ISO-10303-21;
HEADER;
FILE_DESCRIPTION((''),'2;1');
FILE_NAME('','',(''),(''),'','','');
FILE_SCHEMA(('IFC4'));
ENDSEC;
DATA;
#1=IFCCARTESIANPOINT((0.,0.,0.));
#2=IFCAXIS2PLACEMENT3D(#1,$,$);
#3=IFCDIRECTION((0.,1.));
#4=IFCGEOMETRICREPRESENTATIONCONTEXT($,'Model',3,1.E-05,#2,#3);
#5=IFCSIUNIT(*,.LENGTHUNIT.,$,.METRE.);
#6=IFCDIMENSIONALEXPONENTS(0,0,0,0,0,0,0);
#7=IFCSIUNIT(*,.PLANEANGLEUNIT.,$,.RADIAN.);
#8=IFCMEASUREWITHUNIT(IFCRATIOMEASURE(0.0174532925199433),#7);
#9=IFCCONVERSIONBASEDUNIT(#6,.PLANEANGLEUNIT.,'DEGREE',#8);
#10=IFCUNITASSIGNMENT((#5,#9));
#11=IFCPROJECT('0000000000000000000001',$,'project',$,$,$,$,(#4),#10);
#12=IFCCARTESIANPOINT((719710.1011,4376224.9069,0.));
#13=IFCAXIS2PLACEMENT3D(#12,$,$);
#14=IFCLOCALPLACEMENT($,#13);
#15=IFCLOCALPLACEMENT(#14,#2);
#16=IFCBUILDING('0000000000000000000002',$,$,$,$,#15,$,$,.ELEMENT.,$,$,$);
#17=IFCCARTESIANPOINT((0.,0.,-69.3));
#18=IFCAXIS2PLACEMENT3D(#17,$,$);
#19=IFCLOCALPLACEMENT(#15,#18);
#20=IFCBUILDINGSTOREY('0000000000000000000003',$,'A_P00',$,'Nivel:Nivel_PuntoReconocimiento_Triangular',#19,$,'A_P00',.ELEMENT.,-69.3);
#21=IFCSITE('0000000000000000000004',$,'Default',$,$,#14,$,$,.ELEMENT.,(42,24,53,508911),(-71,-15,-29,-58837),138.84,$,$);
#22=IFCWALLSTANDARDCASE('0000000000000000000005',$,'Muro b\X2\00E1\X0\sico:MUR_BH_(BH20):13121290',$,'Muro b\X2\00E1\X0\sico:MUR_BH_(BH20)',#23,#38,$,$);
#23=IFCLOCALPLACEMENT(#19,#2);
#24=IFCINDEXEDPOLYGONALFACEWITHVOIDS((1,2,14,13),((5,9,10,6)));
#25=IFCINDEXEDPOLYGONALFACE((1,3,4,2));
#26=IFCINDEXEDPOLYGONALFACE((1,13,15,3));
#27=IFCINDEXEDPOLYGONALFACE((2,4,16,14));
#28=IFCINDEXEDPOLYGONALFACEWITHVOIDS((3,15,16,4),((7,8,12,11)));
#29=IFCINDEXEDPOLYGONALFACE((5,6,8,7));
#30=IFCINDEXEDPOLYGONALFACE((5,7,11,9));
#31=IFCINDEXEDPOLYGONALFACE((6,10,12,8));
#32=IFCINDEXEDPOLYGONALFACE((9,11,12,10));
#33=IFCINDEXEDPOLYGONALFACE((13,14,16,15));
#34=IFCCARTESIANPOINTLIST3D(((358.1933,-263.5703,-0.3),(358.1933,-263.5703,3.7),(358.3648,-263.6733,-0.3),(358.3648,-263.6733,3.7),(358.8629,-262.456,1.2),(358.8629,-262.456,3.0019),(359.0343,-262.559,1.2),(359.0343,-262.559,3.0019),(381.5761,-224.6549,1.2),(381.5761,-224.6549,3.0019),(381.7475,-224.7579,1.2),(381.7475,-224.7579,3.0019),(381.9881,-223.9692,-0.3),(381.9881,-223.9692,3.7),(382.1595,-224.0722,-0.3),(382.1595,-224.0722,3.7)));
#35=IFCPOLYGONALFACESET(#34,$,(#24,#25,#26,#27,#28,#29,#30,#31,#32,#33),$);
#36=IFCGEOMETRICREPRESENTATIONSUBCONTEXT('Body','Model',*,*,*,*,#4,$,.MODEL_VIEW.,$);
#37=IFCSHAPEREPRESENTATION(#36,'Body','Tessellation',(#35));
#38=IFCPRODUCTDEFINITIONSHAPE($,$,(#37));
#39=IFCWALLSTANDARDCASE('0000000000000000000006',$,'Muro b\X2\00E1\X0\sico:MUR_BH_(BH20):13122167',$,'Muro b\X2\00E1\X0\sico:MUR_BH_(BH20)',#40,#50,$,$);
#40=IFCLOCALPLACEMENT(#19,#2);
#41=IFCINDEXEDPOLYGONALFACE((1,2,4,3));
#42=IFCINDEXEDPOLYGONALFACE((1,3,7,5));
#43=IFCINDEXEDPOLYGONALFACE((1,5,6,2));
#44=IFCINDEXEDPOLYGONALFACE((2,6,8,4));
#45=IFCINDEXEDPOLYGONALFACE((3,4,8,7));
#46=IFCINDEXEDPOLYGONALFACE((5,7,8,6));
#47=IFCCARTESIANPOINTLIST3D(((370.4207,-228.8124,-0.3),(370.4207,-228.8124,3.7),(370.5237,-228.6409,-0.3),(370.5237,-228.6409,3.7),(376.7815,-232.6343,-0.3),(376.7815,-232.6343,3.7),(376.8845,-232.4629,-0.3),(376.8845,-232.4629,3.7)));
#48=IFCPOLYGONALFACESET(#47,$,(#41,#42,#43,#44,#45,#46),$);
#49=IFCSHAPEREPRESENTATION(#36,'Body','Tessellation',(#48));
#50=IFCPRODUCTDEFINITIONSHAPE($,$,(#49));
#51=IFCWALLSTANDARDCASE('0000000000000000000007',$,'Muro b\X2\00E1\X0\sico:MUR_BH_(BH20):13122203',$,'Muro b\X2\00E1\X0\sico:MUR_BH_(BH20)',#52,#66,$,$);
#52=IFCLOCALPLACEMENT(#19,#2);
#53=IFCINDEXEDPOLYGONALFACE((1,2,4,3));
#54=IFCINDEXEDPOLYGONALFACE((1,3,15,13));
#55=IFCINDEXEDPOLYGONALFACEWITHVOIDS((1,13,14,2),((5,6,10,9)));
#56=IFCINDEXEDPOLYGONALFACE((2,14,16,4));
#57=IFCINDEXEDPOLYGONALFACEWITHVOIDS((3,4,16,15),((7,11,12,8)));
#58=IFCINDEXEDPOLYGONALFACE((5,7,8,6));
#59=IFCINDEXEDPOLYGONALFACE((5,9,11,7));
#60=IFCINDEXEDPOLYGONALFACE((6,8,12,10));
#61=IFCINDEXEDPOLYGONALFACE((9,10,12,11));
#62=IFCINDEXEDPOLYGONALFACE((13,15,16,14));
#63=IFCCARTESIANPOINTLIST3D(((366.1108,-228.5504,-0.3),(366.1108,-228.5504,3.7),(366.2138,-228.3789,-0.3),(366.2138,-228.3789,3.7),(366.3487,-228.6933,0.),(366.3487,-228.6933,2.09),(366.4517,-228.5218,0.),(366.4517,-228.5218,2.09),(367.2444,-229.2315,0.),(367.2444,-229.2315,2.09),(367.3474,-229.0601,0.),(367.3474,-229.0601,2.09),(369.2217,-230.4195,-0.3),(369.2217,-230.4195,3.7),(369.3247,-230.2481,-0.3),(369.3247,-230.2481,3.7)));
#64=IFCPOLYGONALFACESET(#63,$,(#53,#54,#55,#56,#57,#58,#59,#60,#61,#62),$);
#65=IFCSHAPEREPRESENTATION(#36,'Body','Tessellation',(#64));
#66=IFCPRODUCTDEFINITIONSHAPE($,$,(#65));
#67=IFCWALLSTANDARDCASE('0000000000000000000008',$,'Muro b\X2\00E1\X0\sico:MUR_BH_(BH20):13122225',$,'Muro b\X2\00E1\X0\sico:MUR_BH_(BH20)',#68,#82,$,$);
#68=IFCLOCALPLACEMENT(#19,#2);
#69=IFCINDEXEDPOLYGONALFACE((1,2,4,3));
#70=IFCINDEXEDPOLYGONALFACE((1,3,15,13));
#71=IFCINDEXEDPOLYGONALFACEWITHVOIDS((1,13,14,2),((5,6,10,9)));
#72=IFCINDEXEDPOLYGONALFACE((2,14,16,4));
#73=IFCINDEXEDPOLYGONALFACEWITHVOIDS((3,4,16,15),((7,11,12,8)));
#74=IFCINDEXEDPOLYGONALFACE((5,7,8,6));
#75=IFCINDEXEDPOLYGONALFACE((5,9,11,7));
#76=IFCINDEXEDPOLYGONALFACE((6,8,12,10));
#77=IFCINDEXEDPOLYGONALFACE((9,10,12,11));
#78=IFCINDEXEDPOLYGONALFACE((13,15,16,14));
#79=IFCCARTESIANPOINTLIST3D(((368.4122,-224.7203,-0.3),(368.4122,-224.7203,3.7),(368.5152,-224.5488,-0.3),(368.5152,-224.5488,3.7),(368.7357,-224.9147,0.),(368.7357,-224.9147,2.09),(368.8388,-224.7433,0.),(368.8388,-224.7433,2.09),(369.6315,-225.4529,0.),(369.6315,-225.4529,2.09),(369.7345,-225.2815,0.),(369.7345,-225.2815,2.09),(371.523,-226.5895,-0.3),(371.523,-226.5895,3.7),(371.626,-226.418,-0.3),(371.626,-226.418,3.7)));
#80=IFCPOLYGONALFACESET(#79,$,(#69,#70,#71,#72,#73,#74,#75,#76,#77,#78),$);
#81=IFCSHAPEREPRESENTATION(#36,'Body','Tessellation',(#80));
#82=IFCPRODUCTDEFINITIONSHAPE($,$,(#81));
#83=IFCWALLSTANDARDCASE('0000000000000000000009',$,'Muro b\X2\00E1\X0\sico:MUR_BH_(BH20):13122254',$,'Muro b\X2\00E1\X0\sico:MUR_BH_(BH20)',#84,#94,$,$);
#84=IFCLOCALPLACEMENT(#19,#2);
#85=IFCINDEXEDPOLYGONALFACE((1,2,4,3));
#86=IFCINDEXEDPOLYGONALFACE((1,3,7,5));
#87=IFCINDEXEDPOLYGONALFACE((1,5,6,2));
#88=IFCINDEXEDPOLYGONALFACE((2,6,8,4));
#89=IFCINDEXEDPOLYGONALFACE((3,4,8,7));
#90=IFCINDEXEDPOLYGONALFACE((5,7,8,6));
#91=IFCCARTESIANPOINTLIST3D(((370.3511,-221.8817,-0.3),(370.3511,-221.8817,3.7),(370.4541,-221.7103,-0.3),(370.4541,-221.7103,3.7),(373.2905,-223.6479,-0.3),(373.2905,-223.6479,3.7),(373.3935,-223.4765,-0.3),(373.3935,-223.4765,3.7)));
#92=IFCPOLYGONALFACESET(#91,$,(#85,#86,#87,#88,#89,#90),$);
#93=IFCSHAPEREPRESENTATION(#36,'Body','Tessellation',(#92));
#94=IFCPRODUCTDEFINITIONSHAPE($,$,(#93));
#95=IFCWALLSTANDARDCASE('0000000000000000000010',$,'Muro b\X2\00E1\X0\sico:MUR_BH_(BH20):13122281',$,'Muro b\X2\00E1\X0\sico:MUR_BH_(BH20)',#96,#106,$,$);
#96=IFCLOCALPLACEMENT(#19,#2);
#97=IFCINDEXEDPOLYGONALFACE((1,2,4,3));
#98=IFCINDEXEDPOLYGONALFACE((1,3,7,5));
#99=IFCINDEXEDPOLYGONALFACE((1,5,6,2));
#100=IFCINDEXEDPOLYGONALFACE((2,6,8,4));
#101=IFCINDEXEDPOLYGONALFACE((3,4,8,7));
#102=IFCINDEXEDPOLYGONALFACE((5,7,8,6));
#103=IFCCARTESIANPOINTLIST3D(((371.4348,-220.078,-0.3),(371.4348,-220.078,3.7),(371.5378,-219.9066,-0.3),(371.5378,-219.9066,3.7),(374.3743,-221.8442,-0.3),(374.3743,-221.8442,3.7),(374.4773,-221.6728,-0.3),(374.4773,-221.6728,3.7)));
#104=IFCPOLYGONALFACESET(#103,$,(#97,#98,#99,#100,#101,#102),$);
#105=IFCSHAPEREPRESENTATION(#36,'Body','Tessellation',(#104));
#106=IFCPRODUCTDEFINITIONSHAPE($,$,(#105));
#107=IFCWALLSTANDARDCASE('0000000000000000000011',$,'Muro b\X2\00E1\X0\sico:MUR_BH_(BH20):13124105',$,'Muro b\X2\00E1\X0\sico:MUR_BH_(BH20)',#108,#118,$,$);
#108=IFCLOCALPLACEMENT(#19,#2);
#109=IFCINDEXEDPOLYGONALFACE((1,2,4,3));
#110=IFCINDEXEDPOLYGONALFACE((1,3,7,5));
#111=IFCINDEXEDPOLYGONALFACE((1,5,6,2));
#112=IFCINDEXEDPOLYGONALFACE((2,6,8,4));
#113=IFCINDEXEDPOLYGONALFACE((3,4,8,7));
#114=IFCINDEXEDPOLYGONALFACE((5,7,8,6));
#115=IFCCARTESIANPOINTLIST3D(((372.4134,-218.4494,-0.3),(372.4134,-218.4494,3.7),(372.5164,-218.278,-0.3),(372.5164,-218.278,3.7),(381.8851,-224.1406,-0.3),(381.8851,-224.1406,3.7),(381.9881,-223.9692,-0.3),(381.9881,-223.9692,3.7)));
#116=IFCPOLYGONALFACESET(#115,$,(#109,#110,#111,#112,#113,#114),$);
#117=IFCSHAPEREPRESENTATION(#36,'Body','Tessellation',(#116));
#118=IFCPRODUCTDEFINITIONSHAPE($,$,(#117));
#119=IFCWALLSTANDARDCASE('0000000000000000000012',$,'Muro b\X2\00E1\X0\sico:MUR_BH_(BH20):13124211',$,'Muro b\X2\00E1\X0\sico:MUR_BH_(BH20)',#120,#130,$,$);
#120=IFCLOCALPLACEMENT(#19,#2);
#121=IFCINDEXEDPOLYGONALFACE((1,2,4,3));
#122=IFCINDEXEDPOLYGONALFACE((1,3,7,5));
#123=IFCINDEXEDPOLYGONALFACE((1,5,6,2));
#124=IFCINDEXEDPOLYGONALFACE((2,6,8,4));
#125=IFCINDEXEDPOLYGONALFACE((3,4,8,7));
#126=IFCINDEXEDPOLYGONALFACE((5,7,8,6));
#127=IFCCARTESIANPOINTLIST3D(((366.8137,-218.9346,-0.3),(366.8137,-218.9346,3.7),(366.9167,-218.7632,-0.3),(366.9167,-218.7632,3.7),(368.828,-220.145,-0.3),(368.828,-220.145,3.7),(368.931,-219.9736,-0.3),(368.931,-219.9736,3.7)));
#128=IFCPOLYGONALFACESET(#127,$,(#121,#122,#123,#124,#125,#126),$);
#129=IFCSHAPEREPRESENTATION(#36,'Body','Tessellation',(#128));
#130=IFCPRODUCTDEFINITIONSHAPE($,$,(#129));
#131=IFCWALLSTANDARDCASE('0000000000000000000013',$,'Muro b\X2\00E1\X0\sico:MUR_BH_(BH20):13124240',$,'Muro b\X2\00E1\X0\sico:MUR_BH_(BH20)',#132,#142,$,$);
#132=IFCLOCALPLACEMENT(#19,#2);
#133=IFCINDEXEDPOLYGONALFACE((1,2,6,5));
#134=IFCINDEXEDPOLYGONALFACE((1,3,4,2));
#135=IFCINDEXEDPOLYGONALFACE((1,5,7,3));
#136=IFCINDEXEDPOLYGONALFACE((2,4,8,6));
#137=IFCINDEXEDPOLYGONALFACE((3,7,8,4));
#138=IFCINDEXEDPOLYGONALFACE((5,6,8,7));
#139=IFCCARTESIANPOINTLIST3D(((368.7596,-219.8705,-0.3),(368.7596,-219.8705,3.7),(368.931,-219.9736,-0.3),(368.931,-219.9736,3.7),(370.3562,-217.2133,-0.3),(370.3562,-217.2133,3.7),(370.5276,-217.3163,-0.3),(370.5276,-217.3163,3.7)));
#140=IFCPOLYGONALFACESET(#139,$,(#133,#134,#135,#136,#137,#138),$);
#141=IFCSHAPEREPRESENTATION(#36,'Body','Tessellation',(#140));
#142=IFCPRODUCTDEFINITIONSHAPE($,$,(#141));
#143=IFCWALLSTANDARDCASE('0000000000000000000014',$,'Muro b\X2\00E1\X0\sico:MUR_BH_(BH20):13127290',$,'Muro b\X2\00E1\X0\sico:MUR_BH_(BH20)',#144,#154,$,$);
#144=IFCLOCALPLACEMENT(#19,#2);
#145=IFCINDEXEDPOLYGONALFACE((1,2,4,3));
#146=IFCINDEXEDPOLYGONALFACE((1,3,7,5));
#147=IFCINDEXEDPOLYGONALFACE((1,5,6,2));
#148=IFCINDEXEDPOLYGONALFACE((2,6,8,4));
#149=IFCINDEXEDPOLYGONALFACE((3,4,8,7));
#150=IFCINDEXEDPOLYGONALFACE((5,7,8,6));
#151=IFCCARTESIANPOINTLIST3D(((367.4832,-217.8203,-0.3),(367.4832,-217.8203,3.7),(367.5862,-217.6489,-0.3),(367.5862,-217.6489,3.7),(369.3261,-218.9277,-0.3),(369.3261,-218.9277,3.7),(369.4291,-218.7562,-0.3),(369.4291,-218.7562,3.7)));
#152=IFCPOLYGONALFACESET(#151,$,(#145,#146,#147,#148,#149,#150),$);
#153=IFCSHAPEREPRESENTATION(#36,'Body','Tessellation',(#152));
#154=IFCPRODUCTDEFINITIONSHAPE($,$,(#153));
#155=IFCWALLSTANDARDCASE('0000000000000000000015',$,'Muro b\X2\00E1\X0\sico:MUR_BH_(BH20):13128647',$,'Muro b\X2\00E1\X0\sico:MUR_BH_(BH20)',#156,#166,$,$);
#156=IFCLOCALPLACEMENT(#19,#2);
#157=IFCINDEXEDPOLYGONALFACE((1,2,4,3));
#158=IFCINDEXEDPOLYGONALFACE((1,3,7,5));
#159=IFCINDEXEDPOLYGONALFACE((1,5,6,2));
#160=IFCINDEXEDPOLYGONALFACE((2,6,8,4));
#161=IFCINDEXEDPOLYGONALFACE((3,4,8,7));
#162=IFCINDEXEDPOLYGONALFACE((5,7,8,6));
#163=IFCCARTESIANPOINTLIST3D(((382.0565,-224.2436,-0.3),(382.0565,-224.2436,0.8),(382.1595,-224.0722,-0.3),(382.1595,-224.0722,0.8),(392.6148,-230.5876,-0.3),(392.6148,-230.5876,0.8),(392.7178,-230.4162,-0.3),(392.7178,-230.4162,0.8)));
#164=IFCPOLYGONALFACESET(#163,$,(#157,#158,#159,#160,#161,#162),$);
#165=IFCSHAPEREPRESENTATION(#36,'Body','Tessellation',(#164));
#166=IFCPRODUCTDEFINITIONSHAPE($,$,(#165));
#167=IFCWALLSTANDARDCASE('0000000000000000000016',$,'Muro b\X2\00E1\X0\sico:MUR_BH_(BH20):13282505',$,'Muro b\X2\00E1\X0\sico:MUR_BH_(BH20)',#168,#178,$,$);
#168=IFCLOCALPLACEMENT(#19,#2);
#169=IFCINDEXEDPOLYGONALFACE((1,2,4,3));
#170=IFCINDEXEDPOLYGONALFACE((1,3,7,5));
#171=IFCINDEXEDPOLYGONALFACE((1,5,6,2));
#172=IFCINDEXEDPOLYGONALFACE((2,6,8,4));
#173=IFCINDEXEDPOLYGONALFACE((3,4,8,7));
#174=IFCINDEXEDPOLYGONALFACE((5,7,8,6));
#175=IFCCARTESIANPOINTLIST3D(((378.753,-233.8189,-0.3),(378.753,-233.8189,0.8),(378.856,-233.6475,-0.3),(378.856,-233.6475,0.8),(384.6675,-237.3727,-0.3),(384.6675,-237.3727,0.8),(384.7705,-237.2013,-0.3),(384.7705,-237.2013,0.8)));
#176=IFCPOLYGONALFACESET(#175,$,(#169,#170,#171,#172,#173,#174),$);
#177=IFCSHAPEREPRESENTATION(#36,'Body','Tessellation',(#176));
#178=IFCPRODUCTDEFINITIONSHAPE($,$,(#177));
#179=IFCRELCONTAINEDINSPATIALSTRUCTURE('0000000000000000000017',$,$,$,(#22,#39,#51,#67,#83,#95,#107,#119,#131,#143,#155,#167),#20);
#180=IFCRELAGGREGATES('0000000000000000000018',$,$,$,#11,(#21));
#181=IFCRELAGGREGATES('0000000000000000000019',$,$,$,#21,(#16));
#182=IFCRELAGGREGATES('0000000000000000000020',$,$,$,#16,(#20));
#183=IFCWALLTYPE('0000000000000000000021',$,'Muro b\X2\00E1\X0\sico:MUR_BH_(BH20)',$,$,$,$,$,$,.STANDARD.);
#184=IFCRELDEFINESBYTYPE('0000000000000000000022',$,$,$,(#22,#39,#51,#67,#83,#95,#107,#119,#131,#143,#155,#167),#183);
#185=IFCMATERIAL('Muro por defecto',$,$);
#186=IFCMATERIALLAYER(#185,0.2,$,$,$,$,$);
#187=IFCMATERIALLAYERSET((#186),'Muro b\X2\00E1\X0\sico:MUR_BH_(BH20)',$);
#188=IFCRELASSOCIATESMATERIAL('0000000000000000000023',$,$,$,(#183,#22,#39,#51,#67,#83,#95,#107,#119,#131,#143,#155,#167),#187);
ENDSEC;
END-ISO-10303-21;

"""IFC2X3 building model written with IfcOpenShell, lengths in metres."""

from ifc_helpers import new_model, entity, si_unit, converted_unit, direction, frame, frame_2d, origin, place, context, subcontext, project, spatial, rectangle, extrude, material, layer, layer_set, layer_usage, type_object, element, save


model = new_model("IFC2X3")

# Units and contexts
model_context = context("Model", 3, precision=1e-05, world=origin(), true_north=direction((0.0, 1.0)))
body_context = subcontext(model_context, "Body", "Model", "MODEL_VIEW")
ifc_project = project(units=[si_unit("LENGTHUNIT", "METRE"), converted_unit("PLANEANGLEUNIT", "DEGREE", entity("IfcRatioMeasure", 0.0174532925199433), si_unit("PLANEANGLEUNIT", "RADIAN"), dimensions=[0, 0, 0, 0, 0, 0, 0])], contexts=[model_context])

# Site, building, storey
site_placement = place(None, frame((719710.1011, 4376224.9069, 0.0)))
site = spatial("IfcSite", under=ifc_project, at=site_placement, Name="Default", CompositionType="ELEMENT", RefLatitude=(42, 24, 53, 508911), RefLongitude=(-71, -15, -29, -58837), RefElevation=138.84)
building_placement = place(site_placement, origin())
building = spatial("IfcBuilding", under=site, at=building_placement, CompositionType="ELEMENT")
storey_placement = place(building_placement, frame((0.0, 0.0, -69.3)))
storey = spatial("IfcBuildingStorey", under=building, at=storey_placement, Name="A_P00", ObjectType="Nivel:Nivel_PuntoReconocimiento_Triangular", LongName="A_P00", CompositionType="ELEMENT", Elevation=-69.3)

# Wall, opening
ifc_material_1 = material(Name="Muro por defecto")
ifc_layer = layer(ifc_material_1, 0.2)
ifc_layer_set = layer_set([ifc_layer], Name="Muro básico:MUR_BH_(BH20)")
wall_type = type_object("IfcWallType", Name="Muro básico:MUR_BH_(BH20)", PredefinedType="STANDARD", material=ifc_layer_set)
ifc_layer_usage_1 = layer_usage(ifc_layer_set, "AXIS2", "NEGATIVE", 0.1)
wall_1_placement = place(storey_placement, frame((382.0738, -224.0207, -0.3), z_axis=(0.0, 0.0, 1.0), x_axis=(-0.515038, -0.857167, 0.0)))
wall_1 = element("IfcWallStandardCase", 1, at=wall_1_placement, inside=storey, type_object=wall_type, material=ifc_layer_usage_1, Name="Muro básico:MUR_BH_(BH20):13121290", ObjectType="Muro básico:MUR_BH_(BH20)", context=body_context, shape_type="SweptSolid", body=[
    extrude(rectangle(XDim=46.2, YDim=0.2, at=frame_2d((23.1, 0.0), x_axis=(-1.0, 0.0))), origin(), (0.0, 0.0, 1.0), 4.0),
])
opening_1_placement = place(wall_1_placement, origin())
element("IfcOpeningElement", 2, at=opening_1_placement, cuts=wall_1, ObjectType="Opening", context=body_context, shape_type="SweptSolid", body=[
    extrude(rectangle(XDim=1.8019, YDim=44.1, at=frame_2d((0.0, 0.0), x_axis=(0.0, 1.0))), frame((22.85, -0.2524, 2.4009), z_axis=(0.0, 1.0, 0.0), x_axis=(-1.0, 0.0, 0.0)), (0.0, 0.0, 1.0), 0.5048),
])

# Wall
ifc_layer_usage_2 = layer_usage(ifc_layer_set, "AXIS2", "NEGATIVE", 0.1)
wall_2_placement = place(storey_placement, frame((370.4722, -228.7266, -0.3), z_axis=(0.0, 0.0, 1.0), x_axis=(0.857167, -0.515038, 0.0)))
element("IfcWallStandardCase", 3, at=wall_2_placement, inside=storey, type_object=wall_type, material=ifc_layer_usage_2, Name="Muro básico:MUR_BH_(BH20):13122167", ObjectType="Muro básico:MUR_BH_(BH20)", context=body_context, shape_type="SweptSolid", body=[
    extrude(rectangle(XDim=7.4208, YDim=0.2, at=frame_2d((3.7104, 0.0), x_axis=(-1.0, 0.0))), origin(), (0.0, 0.0, 1.0), 4.0),
])

# Walls, openings
ifc_layer_usage_3 = layer_usage(ifc_layer_set, "AXIS2", "NEGATIVE", 0.1)
wall_3_placement = place(storey_placement, frame((366.1623, -228.4646, -0.3), z_axis=(0.0, 0.0, 1.0), x_axis=(0.857167, -0.515038, 0.0)))
wall_3 = element("IfcWallStandardCase", 4, at=wall_3_placement, inside=storey, type_object=wall_type, material=ifc_layer_usage_3, Name="Muro básico:MUR_BH_(BH20):13122203", ObjectType="Muro básico:MUR_BH_(BH20)", context=body_context, shape_type="SweptSolid", body=[
    extrude(rectangle(XDim=3.6292, YDim=0.2, at=frame_2d((1.8146, 0.0), x_axis=(-1.0, 0.0))), origin(), (0.0, 0.0, 1.0), 4.0),
])
opening_2_placement = place(wall_3_placement, frame((-431.5304, 7.2449, 0.3), z_axis=(0.0, 0.0, 1.0), x_axis=(0.857167, 0.515038, 0.0)))
element("IfcOpeningElement", 5, at=opening_2_placement, cuts=wall_3, ObjectType="Opening", context=body_context, shape_type="SweptSolid", body=[
    extrude(rectangle(XDim=2.09, YDim=1.045, at=frame_2d((0.0, 0.0), x_axis=(0.0, 1.0))), frame((366.7966, -228.9624, 1.045), z_axis=(0.515038, 0.857167, 0.0), x_axis=(0.857167, -0.515038, 0.0)), (0.0, 0.0, 1.0), 0.2),
])
ifc_layer_usage_4 = layer_usage(ifc_layer_set, "AXIS2", "NEGATIVE", 0.1)
wall_4_placement = place(storey_placement, frame((368.4637, -224.6346, -0.3), z_axis=(0.0, 0.0, 1.0), x_axis=(0.857167, -0.515038, 0.0)))
wall_4 = element("IfcWallStandardCase", 6, at=wall_4_placement, inside=storey, type_object=wall_type, material=ifc_layer_usage_4, Name="Muro básico:MUR_BH_(BH20):13122225", ObjectType="Muro básico:MUR_BH_(BH20)", context=body_context, shape_type="SweptSolid", body=[
    extrude(rectangle(XDim=3.6292, YDim=0.2, at=frame_2d((1.8146, 0.0), x_axis=(-1.0, 0.0))), origin(), (0.0, 0.0, 1.0), 4.0),
])
opening_3_placement = place(wall_4_placement, frame((-431.5304, 2.7766, 0.3), z_axis=(0.0, 0.0, 1.0), x_axis=(0.857167, 0.515038, 0.0)))
element("IfcOpeningElement", 7, at=opening_3_placement, cuts=wall_4, ObjectType="Opening", context=body_context, shape_type="SweptSolid", body=[
    extrude(rectangle(XDim=2.09, YDim=1.045, at=frame_2d((0.0, 0.0), x_axis=(0.0, 1.0))), frame((369.1836, -225.1838, 1.045), z_axis=(0.515038, 0.857167, 0.0), x_axis=(0.857167, -0.515038, 0.0)), (0.0, 0.0, 1.0), 0.2),
])

# Walls
ifc_layer_usage_5 = layer_usage(ifc_layer_set, "AXIS2", "NEGATIVE", 0.1)
wall_5_placement = place(storey_placement, frame((370.4026, -221.796, -0.3), z_axis=(0.0, 0.0, 1.0), x_axis=(0.857167, -0.515038, 0.0)))
element("IfcWallStandardCase", 8, at=wall_5_placement, inside=storey, type_object=wall_type, material=ifc_layer_usage_5, Name="Muro básico:MUR_BH_(BH20):13122254", ObjectType="Muro básico:MUR_BH_(BH20)", context=body_context, shape_type="SweptSolid", body=[
    extrude(rectangle(XDim=3.4292, YDim=0.2, at=frame_2d((1.7146, 0.0), x_axis=(-1.0, 0.0))), origin(), (0.0, 0.0, 1.0), 4.0),
])
ifc_layer_usage_6 = layer_usage(ifc_layer_set, "AXIS2", "NEGATIVE", 0.1)
wall_6_placement = place(storey_placement, frame((371.4863, -219.9923, -0.3), z_axis=(0.0, 0.0, 1.0), x_axis=(0.857167, -0.515038, 0.0)))
element("IfcWallStandardCase", 9, at=wall_6_placement, inside=storey, type_object=wall_type, material=ifc_layer_usage_6, Name="Muro básico:MUR_BH_(BH20):13122281", ObjectType="Muro básico:MUR_BH_(BH20)", context=body_context, shape_type="SweptSolid", body=[
    extrude(rectangle(XDim=3.4292, YDim=0.2, at=frame_2d((1.7146, 0.0), x_axis=(-1.0, 0.0))), origin(), (0.0, 0.0, 1.0), 4.0),
])
ifc_layer_usage_7 = layer_usage(ifc_layer_set, "AXIS2", "NEGATIVE", 0.1)
wall_7_placement = place(storey_placement, frame((372.4649, -218.3637, -0.3), z_axis=(0.0, 0.0, 1.0), x_axis=(0.857167, -0.515038, 0.0)))
element("IfcWallStandardCase", 10, at=wall_7_placement, inside=storey, type_object=wall_type, material=ifc_layer_usage_7, Name="Muro básico:MUR_BH_(BH20):13124105", ObjectType="Muro básico:MUR_BH_(BH20)", context=body_context, shape_type="SweptSolid", body=[
    extrude(rectangle(XDim=11.05, YDim=0.2, at=frame_2d((5.525, 0.0), x_axis=(-1.0, 0.0))), origin(), (0.0, 0.0, 1.0), 4.0),
])
ifc_layer_usage_8 = layer_usage(ifc_layer_set, "AXIS2", "NEGATIVE", 0.1)
wall_8_placement = place(storey_placement, frame((366.8652, -218.8489, -0.3), z_axis=(0.0, 0.0, 1.0), x_axis=(0.857167, -0.515038, 0.0)))
element("IfcWallStandardCase", 11, at=wall_8_placement, inside=storey, type_object=wall_type, material=ifc_layer_usage_8, Name="Muro básico:MUR_BH_(BH20):13124211", ObjectType="Muro básico:MUR_BH_(BH20)", context=body_context, shape_type="SweptSolid", body=[
    extrude(rectangle(XDim=2.35, YDim=0.2, at=frame_2d((1.175, 0.0), x_axis=(-1.0, 0.0))), origin(), (0.0, 0.0, 1.0), 4.0),
])
ifc_layer_usage_9 = layer_usage(ifc_layer_set, "AXIS2", "NEGATIVE", 0.1)
wall_9_placement = place(storey_placement, frame((368.8453, -219.9221, -0.3), z_axis=(0.0, 0.0, 1.0), x_axis=(0.515038, 0.857167, 0.0)))
element("IfcWallStandardCase", 12, at=wall_9_placement, inside=storey, type_object=wall_type, material=ifc_layer_usage_9, Name="Muro básico:MUR_BH_(BH20):13124240", ObjectType="Muro básico:MUR_BH_(BH20)", context=body_context, shape_type="SweptSolid", body=[
    extrude(rectangle(XDim=3.1, YDim=0.2, at=frame_2d((1.55, 0.0), x_axis=(-1.0, 0.0))), origin(), (0.0, 0.0, 1.0), 4.0),
])
ifc_layer_usage_10 = layer_usage(ifc_layer_set, "AXIS2", "NEGATIVE", 0.1)
wall_10_placement = place(storey_placement, frame((367.5347, -217.7346, -0.3), z_axis=(0.0, 0.0, 1.0), x_axis=(0.857167, -0.515038, 0.0)))
element("IfcWallStandardCase", 13, at=wall_10_placement, inside=storey, type_object=wall_type, material=ifc_layer_usage_10, Name="Muro básico:MUR_BH_(BH20):13127290", ObjectType="Muro básico:MUR_BH_(BH20)", context=body_context, shape_type="SweptSolid", body=[
    extrude(rectangle(XDim=2.15, YDim=0.2, at=frame_2d((1.075, 0.0), x_axis=(-1.0, 0.0))), origin(), (0.0, 0.0, 1.0), 4.0),
])

# Walls
ifc_layer_usage_11 = layer_usage(ifc_layer_set, "AXIS2", "NEGATIVE", 0.1)
wall_11_placement = place(storey_placement, frame((392.6663, -230.5019, -0.3), z_axis=(0.0, 0.0, 1.0), x_axis=(-0.857167, 0.515038, 0.0)))
element("IfcWallStandardCase", 14, at=wall_11_placement, inside=storey, type_object=wall_type, material=ifc_layer_usage_11, Name="Muro básico:MUR_BH_(BH20):13128647", ObjectType="Muro básico:MUR_BH_(BH20)", context=body_context, shape_type="SweptSolid", body=[
    extrude(rectangle(XDim=12.3176, YDim=0.2, at=frame_2d((6.1588, 0.0), x_axis=(-1.0, 0.0))), origin(), (0.0, 0.0, 1.0), 1.1),
])
ifc_layer_usage_12 = layer_usage(ifc_layer_set, "AXIS2", "NEGATIVE", 0.1)
wall_12_placement = place(storey_placement, frame((378.8045, -233.7332, -0.3), z_axis=(0.0, 0.0, 1.0), x_axis=(0.857167, -0.515038, 0.0)))
element("IfcWallStandardCase", 15, at=wall_12_placement, inside=storey, type_object=wall_type, material=ifc_layer_usage_12, Name="Muro básico:MUR_BH_(BH20):13282505", ObjectType="Muro básico:MUR_BH_(BH20)", context=body_context, shape_type="SweptSolid", body=[
    extrude(rectangle(XDim=6.9, YDim=0.2, at=frame_2d((3.45, 0.0), x_axis=(-1.0, 0.0))), origin(), (0.0, 0.0, 1.0), 1.1),
])

save(model, "model.ifc")
